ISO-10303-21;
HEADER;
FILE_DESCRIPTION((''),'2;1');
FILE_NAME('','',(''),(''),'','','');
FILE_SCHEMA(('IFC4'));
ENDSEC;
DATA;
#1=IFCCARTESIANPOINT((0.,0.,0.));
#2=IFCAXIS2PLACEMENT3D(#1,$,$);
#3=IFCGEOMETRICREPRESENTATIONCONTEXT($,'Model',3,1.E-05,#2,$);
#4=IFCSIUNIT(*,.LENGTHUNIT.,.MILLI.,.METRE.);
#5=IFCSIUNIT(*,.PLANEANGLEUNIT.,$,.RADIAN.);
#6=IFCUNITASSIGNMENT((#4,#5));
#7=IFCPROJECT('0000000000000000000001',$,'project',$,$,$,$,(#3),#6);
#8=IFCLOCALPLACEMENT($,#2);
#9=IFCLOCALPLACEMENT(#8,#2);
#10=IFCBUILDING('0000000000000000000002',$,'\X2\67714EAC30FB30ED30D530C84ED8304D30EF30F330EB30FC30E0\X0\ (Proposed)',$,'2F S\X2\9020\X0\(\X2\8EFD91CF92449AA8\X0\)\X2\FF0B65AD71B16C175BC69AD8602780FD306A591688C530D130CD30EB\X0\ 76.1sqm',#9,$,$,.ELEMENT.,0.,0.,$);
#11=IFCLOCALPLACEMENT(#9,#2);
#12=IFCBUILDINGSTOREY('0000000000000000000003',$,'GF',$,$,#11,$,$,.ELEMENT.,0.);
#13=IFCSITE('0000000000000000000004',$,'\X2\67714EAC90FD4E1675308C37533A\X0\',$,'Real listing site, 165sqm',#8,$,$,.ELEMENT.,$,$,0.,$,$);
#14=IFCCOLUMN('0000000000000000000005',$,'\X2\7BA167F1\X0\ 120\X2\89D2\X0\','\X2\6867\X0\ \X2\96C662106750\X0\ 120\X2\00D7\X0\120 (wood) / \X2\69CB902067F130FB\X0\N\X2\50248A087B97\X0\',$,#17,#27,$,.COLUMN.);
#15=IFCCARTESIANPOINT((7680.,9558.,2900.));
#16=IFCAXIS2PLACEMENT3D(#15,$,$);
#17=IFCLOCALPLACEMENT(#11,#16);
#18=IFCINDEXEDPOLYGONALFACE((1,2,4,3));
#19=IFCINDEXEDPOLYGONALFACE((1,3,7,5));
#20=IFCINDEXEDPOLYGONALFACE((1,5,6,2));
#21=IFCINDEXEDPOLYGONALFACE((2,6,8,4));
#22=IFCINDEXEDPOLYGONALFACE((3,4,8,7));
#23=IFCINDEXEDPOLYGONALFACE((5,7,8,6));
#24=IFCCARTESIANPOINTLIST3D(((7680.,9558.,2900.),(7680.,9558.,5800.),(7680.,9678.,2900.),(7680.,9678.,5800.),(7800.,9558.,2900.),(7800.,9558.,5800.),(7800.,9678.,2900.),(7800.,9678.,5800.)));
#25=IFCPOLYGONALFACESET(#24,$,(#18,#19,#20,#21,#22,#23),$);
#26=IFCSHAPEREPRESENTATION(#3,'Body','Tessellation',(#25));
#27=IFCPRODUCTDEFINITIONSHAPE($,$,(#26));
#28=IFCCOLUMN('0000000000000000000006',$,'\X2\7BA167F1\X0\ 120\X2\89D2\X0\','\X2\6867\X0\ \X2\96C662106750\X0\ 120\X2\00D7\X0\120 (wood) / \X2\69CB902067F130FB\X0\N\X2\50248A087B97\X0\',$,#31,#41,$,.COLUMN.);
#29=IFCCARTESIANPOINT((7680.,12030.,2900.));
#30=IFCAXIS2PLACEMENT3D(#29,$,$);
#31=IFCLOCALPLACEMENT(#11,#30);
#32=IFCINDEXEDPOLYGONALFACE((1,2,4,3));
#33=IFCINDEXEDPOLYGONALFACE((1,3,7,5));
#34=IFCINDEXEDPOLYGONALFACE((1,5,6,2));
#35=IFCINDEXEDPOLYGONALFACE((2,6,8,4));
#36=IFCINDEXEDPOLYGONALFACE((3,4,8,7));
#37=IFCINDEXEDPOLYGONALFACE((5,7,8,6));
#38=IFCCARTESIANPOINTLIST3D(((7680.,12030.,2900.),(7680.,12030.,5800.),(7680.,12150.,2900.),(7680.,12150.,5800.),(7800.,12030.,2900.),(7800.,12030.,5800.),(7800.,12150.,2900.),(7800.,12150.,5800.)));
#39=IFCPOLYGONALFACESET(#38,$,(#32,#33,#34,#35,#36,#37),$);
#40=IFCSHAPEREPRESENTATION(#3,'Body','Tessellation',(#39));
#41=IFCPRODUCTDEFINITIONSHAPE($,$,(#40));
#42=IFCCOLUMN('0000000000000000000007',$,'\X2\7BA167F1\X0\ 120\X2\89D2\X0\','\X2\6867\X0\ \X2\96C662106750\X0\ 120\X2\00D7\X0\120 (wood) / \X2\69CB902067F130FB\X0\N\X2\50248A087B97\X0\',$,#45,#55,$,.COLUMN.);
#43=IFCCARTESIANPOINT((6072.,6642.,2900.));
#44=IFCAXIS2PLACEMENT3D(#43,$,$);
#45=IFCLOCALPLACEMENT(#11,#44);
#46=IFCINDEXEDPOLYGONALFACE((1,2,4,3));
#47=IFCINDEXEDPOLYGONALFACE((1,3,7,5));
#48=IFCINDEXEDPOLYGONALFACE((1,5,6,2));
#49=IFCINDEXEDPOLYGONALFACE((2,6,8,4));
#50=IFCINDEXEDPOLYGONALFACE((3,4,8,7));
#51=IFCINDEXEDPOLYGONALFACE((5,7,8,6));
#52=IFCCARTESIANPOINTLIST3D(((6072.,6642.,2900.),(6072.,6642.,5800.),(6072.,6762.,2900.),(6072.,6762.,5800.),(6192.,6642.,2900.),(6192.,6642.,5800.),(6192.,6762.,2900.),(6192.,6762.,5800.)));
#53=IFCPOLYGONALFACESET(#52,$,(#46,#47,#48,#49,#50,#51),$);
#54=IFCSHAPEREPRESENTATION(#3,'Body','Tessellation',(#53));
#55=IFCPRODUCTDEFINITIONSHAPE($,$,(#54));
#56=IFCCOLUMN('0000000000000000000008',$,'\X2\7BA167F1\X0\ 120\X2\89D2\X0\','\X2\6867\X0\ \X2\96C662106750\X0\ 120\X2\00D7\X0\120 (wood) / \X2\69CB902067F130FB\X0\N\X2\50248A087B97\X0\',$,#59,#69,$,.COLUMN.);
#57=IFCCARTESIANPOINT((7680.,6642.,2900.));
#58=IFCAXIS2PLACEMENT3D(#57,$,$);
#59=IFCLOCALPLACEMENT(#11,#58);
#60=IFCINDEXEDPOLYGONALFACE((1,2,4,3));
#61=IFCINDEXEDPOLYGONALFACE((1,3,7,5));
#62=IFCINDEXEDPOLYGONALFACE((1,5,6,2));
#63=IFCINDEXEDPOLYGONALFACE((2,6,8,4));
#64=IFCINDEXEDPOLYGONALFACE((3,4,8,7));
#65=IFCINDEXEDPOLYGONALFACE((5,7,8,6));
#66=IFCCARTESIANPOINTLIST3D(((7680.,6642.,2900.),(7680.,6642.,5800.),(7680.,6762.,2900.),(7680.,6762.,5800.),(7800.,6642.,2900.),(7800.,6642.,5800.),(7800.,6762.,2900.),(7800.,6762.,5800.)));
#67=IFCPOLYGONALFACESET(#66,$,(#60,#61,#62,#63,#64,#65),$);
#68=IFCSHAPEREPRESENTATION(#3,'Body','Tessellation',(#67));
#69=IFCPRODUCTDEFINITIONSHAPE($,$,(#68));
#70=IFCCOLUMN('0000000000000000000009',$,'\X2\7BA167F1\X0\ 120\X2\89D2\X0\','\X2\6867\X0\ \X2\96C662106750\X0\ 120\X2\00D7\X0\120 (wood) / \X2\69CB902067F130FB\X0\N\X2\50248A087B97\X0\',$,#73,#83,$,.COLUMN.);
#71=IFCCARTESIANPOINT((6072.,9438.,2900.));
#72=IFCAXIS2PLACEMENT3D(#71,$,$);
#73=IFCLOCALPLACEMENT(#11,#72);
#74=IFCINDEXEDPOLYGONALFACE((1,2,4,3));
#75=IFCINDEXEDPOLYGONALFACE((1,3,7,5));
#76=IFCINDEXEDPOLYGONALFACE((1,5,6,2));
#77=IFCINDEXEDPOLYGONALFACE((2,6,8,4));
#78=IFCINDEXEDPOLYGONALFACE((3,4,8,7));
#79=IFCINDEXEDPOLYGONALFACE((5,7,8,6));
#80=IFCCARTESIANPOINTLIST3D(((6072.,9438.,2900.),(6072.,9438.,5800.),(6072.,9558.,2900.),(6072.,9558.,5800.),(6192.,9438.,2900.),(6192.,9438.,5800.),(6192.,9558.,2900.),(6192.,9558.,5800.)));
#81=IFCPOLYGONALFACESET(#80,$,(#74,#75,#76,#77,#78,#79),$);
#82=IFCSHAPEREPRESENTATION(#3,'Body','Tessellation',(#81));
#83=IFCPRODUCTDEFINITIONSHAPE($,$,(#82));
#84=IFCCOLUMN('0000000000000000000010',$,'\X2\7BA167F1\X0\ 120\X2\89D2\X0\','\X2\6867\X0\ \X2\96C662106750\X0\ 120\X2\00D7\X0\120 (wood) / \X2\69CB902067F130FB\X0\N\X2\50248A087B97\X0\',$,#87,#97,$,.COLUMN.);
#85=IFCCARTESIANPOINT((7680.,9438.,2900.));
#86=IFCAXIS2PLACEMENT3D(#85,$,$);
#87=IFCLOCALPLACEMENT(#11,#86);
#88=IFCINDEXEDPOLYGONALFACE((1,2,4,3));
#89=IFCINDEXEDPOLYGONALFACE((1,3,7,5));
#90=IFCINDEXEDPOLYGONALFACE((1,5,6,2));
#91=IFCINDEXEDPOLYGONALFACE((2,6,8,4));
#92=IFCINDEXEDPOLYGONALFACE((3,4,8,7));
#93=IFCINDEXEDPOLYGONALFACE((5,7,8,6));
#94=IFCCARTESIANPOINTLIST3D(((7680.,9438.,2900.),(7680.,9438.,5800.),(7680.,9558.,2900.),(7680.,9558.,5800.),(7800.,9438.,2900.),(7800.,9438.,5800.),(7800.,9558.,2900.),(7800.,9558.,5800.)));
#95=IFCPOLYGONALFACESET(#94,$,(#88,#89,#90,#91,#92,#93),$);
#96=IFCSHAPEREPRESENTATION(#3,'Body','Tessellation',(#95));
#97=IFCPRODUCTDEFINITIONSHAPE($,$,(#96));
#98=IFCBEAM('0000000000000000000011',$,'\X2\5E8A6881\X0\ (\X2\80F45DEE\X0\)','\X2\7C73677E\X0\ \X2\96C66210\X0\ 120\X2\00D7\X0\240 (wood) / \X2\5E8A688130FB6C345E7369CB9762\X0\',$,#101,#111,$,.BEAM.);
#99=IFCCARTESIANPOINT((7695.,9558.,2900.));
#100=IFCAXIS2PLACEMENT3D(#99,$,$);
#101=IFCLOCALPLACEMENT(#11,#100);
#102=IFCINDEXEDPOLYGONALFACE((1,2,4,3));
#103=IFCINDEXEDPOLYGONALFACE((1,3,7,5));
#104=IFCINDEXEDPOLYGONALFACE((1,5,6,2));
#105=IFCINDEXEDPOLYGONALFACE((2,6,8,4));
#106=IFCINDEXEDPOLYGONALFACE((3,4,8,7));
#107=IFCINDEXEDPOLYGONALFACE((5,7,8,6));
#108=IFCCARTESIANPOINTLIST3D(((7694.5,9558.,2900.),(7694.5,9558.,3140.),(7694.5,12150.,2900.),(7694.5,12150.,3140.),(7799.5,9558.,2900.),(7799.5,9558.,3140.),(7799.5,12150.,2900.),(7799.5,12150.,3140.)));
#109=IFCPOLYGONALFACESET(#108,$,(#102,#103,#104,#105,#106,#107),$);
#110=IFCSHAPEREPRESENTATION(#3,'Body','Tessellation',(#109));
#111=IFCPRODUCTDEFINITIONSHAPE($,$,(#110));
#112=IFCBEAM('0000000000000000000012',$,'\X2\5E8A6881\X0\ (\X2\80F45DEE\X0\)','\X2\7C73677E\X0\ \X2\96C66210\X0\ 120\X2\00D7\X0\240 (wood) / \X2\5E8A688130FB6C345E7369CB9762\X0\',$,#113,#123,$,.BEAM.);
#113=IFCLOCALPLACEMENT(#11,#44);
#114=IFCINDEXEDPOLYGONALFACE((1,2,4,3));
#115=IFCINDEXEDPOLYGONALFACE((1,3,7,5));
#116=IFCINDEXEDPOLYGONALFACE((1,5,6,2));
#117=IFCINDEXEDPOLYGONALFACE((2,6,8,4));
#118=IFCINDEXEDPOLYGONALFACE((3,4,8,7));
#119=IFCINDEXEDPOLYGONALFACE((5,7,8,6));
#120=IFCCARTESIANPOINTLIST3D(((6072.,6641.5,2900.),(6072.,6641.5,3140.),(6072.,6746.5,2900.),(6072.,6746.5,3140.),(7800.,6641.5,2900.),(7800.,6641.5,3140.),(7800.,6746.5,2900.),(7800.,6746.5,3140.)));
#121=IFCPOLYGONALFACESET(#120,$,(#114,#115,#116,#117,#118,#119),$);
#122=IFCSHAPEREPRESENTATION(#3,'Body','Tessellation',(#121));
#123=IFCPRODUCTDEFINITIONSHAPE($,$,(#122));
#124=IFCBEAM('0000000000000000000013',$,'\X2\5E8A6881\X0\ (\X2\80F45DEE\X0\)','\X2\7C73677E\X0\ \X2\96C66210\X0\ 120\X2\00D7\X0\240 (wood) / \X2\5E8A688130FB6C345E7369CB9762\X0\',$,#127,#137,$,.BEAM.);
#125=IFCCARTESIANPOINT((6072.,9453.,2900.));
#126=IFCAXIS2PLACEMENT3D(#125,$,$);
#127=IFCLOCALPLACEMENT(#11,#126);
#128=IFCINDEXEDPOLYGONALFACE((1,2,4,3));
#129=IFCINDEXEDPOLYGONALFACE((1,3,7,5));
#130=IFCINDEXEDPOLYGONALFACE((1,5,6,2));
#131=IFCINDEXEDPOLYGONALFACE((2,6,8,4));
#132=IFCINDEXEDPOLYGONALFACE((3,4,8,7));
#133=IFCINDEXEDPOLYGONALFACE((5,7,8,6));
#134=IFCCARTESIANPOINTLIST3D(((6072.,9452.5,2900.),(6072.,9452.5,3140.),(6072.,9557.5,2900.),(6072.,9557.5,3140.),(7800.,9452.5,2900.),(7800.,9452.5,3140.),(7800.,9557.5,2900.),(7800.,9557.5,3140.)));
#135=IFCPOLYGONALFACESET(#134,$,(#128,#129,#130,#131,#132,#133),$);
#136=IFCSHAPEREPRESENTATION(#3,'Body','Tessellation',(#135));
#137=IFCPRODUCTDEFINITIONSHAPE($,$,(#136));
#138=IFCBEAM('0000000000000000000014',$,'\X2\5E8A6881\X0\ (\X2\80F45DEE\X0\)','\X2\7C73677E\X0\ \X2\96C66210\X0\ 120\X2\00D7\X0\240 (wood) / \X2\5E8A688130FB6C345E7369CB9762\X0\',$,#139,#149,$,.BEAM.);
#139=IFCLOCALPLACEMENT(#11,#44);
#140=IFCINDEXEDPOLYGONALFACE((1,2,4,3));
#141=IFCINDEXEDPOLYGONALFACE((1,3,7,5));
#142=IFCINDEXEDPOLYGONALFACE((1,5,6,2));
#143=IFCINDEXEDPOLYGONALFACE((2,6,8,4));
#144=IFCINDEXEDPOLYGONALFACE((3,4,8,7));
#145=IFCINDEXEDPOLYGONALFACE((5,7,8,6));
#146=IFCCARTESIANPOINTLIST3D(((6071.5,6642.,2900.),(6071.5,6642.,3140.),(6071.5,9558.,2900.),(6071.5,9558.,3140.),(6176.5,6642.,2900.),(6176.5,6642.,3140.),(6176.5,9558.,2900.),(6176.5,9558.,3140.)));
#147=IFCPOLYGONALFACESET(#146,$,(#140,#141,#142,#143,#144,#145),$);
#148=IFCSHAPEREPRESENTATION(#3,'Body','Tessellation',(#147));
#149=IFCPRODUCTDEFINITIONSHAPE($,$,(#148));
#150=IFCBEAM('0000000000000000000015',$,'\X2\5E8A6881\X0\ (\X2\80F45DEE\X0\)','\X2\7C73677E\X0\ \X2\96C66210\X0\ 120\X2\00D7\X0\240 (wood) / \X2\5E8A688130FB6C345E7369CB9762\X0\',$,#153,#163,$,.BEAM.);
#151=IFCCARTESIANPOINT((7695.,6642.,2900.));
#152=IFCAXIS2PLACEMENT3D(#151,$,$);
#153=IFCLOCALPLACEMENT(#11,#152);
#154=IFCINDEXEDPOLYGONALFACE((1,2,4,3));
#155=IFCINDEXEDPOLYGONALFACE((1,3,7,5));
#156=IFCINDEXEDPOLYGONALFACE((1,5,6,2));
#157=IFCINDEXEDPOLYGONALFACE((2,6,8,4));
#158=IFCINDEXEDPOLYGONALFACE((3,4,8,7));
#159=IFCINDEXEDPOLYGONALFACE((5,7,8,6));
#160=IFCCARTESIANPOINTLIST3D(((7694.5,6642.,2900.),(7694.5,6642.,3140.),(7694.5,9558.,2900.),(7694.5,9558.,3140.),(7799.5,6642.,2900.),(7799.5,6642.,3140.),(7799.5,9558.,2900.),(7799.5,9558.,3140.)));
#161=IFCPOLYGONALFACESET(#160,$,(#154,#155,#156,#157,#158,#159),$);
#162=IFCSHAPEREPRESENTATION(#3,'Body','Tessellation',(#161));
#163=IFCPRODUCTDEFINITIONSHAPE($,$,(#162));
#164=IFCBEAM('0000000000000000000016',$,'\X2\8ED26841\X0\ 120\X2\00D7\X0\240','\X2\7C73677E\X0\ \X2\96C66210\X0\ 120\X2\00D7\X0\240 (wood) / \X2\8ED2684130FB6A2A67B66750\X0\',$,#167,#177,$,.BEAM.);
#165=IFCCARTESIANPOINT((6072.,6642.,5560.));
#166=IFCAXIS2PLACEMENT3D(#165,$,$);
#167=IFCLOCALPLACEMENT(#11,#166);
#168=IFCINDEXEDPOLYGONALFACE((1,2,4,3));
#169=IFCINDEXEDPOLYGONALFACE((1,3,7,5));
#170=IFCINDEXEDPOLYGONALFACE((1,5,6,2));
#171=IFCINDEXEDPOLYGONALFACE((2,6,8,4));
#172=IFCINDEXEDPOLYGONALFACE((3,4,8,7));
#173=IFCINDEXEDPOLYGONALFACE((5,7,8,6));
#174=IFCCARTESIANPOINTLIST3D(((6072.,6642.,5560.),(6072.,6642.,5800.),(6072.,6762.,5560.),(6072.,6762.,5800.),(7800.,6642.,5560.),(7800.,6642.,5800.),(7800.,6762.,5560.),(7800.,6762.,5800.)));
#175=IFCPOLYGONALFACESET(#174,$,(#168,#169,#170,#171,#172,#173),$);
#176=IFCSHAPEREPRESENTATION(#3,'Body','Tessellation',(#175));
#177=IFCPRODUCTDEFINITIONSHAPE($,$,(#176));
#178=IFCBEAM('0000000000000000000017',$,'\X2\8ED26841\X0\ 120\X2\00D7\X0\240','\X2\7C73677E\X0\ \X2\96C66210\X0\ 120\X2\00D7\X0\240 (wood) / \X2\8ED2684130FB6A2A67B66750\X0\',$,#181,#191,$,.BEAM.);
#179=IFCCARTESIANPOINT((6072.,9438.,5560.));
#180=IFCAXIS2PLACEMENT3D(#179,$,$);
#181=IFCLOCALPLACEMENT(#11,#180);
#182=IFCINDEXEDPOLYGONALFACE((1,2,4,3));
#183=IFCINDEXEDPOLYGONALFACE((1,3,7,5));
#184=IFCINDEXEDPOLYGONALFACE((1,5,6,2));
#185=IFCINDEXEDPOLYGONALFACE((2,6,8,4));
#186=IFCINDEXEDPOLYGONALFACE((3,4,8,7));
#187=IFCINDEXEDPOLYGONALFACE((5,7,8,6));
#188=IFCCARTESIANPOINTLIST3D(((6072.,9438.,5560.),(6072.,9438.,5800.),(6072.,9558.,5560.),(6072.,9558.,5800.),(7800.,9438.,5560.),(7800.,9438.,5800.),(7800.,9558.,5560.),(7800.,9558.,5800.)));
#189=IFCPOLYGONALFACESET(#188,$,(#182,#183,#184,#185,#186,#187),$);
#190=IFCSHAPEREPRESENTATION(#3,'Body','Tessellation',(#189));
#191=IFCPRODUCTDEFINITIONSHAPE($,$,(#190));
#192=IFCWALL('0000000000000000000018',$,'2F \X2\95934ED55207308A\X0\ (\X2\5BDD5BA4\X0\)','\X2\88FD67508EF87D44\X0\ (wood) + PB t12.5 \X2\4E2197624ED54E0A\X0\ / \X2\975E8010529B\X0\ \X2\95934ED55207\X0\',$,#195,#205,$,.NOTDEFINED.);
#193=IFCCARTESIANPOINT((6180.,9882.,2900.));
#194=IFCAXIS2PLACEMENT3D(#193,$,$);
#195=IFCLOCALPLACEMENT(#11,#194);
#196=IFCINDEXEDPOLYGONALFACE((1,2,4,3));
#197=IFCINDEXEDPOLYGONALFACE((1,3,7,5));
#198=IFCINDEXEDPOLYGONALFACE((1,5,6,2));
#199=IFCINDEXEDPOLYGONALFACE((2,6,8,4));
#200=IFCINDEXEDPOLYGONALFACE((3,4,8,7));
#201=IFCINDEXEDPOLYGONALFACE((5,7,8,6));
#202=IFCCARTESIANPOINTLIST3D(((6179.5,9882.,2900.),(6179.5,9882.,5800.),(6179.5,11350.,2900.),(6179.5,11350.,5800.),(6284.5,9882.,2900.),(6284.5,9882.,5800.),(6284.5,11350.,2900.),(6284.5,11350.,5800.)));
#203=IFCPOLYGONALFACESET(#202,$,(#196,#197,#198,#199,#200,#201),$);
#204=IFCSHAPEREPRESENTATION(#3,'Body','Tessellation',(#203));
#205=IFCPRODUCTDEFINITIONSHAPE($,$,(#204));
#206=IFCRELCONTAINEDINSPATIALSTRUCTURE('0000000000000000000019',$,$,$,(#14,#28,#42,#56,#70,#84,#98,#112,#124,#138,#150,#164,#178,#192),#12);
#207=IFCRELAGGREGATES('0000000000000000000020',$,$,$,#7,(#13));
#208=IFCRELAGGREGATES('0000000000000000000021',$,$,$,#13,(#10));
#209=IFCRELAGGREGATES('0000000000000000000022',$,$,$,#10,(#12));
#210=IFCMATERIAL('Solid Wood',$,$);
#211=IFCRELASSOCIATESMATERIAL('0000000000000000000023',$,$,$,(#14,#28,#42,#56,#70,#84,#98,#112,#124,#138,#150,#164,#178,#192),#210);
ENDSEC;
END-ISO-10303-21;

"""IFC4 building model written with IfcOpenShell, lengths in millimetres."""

from ifc_helpers import new_model, si_unit, frame, frame_2d, origin, place, context, project, spatial, rectangle, extrude, material, element, save


model = new_model("IFC4")

# Units and contexts
model_context = context("Model", 3, precision=1e-05, world=origin())
ifc_project = project(units=[si_unit("LENGTHUNIT", "METRE", prefix="MILLI"), si_unit("PLANEANGLEUNIT", "RADIAN")], contexts=[model_context])

# Site, building, storey
site_placement = place(None, origin())
site = spatial("IfcSite", under=ifc_project, at=site_placement, Name="東京都世田谷区", ObjectType="Real listing site, 165sqm", CompositionType="ELEMENT", RefElevation=0.0)
building_placement = place(site_placement, origin())
building = spatial("IfcBuilding", under=site, at=building_placement, Name="東京・ロフト付きワンルーム (Proposed)", ObjectType="2F S造(軽量鉄骨)＋断熱気密高性能な外装パネル 76.1sqm", CompositionType="ELEMENT", ElevationOfRefHeight=0.0, ElevationOfTerrain=0.0)
storey_placement = place(building_placement, origin())
storey = spatial("IfcBuildingStorey", under=building, at=storey_placement, Name="GF", CompositionType="ELEMENT", Elevation=0.0)

# Columns
ifc_material_1 = material(Name="Solid Wood")
column_1_placement = place(storey_placement, frame((7680.0, 9558.0, 2900.0)))
element("IfcColumn", 1, at=column_1_placement, inside=storey, material=ifc_material_1, Name="管柱 120角", Description="桧 集成材 120×120 (wood) / 構造柱・N値計算", PredefinedType="COLUMN", context=model_context, shape_type="SweptSolid", body=[
    extrude(rectangle(XDim=120.0, YDim=120.0, at=frame_2d((60.0, 60.0))), frame((7680.0, 9558.0, 2900.0)), (0.0, 0.0, 1.0), 2900.0),
])
column_2_placement = place(storey_placement, frame((7680.0, 12030.0, 2900.0)))
element("IfcColumn", 2, at=column_2_placement, inside=storey, material=ifc_material_1, Name="管柱 120角", Description="桧 集成材 120×120 (wood) / 構造柱・N値計算", PredefinedType="COLUMN", context=model_context, shape_type="SweptSolid", body=[
    extrude(rectangle(XDim=120.0, YDim=120.0, at=frame_2d((60.0, 60.0))), frame((7680.0, 12030.0, 2900.0)), (0.0, 0.0, 1.0), 2900.0),
])
column_3_placement = place(storey_placement, frame((6072.0, 6642.0, 2900.0)))
element("IfcColumn", 3, at=column_3_placement, inside=storey, material=ifc_material_1, Name="管柱 120角", Description="桧 集成材 120×120 (wood) / 構造柱・N値計算", PredefinedType="COLUMN", context=model_context, shape_type="SweptSolid", body=[
    extrude(rectangle(XDim=120.0, YDim=120.0, at=frame_2d((60.0, 60.0))), frame((6072.0, 6642.0, 2900.0)), (0.0, 0.0, 1.0), 2900.0),
])
column_4_placement = place(storey_placement, frame((7680.0, 6642.0, 2900.0)))
element("IfcColumn", 4, at=column_4_placement, inside=storey, material=ifc_material_1, Name="管柱 120角", Description="桧 集成材 120×120 (wood) / 構造柱・N値計算", PredefinedType="COLUMN", context=model_context, shape_type="SweptSolid", body=[
    extrude(rectangle(XDim=120.0, YDim=120.0, at=frame_2d((60.0, 60.0))), frame((7680.0, 6642.0, 2900.0)), (0.0, 0.0, 1.0), 2900.0),
])
column_5_placement = place(storey_placement, frame((6072.0, 9438.0, 2900.0)))
element("IfcColumn", 5, at=column_5_placement, inside=storey, material=ifc_material_1, Name="管柱 120角", Description="桧 集成材 120×120 (wood) / 構造柱・N値計算", PredefinedType="COLUMN", context=model_context, shape_type="SweptSolid", body=[
    extrude(rectangle(XDim=120.0, YDim=120.0, at=frame_2d((60.0, 60.0))), frame((6072.0, 9438.0, 2900.0)), (0.0, 0.0, 1.0), 2900.0),
])
column_6_placement = place(storey_placement, frame((7680.0, 9438.0, 2900.0)))
element("IfcColumn", 6, at=column_6_placement, inside=storey, material=ifc_material_1, Name="管柱 120角", Description="桧 集成材 120×120 (wood) / 構造柱・N値計算", PredefinedType="COLUMN", context=model_context, shape_type="SweptSolid", body=[
    extrude(rectangle(XDim=120.0, YDim=120.0, at=frame_2d((60.0, 60.0))), frame((7680.0, 9438.0, 2900.0)), (0.0, 0.0, 1.0), 2900.0),
])

# Beams
beam_1_placement = place(storey_placement, frame((7695.0, 9558.0, 2900.0)))
element("IfcBeam", 7, at=beam_1_placement, inside=storey, material=ifc_material_1, Name="床梁 (胴差)", Description="米松 集成 120×240 (wood) / 床梁・水平構面", PredefinedType="BEAM", context=model_context, shape_type="SweptSolid", body=[
    extrude(rectangle(XDim=105.0, YDim=2592.0, at=frame_2d((52.0, 1296.0))), frame((7695.0, 9558.0, 2900.0)), (0.0, 0.0, 1.0), 240.0),
])
beam_2_placement = place(storey_placement, frame((6072.0, 6642.0, 2900.0)))
element("IfcBeam", 8, at=beam_2_placement, inside=storey, material=ifc_material_1, Name="床梁 (胴差)", Description="米松 集成 120×240 (wood) / 床梁・水平構面", PredefinedType="BEAM", context=model_context, shape_type="SweptSolid", body=[
    extrude(rectangle(XDim=1728.0, YDim=105.0, at=frame_2d((864.0, 52.0))), frame((6072.0, 6642.0, 2900.0)), (0.0, 0.0, 1.0), 240.0),
])
beam_3_placement = place(storey_placement, frame((6072.0, 9453.0, 2900.0)))
element("IfcBeam", 9, at=beam_3_placement, inside=storey, material=ifc_material_1, Name="床梁 (胴差)", Description="米松 集成 120×240 (wood) / 床梁・水平構面", PredefinedType="BEAM", context=model_context, shape_type="SweptSolid", body=[
    extrude(rectangle(XDim=1728.0, YDim=105.0, at=frame_2d((864.0, 52.0))), frame((6072.0, 9453.0, 2900.0)), (0.0, 0.0, 1.0), 240.0),
])
beam_4_placement = place(storey_placement, frame((6072.0, 6642.0, 2900.0)))
element("IfcBeam", 10, at=beam_4_placement, inside=storey, material=ifc_material_1, Name="床梁 (胴差)", Description="米松 集成 120×240 (wood) / 床梁・水平構面", PredefinedType="BEAM", context=model_context, shape_type="SweptSolid", body=[
    extrude(rectangle(XDim=105.0, YDim=2916.0, at=frame_2d((52.0, 1458.0))), frame((6072.0, 6642.0, 2900.0)), (0.0, 0.0, 1.0), 240.0),
])
beam_5_placement = place(storey_placement, frame((7695.0, 6642.0, 2900.0)))
element("IfcBeam", 11, at=beam_5_placement, inside=storey, material=ifc_material_1, Name="床梁 (胴差)", Description="米松 集成 120×240 (wood) / 床梁・水平構面", PredefinedType="BEAM", context=model_context, shape_type="SweptSolid", body=[
    extrude(rectangle(XDim=105.0, YDim=2916.0, at=frame_2d((52.0, 1458.0))), frame((7695.0, 6642.0, 2900.0)), (0.0, 0.0, 1.0), 240.0),
])
beam_6_placement = place(storey_placement, frame((6072.0, 6642.0, 5560.0)))
element("IfcBeam", 12, at=beam_6_placement, inside=storey, material=ifc_material_1, Name="軒桁 120×240", Description="米松 集成 120×240 (wood) / 軒桁・横架材", PredefinedType="BEAM", context=model_context, shape_type="SweptSolid", body=[
    extrude(rectangle(XDim=1728.0, YDim=120.0, at=frame_2d((864.0, 60.0))), frame((6072.0, 6642.0, 5560.0)), (0.0, 0.0, 1.0), 240.0),
])
beam_7_placement = place(storey_placement, frame((6072.0, 9438.0, 5560.0)))
element("IfcBeam", 13, at=beam_7_placement, inside=storey, material=ifc_material_1, Name="軒桁 120×240", Description="米松 集成 120×240 (wood) / 軒桁・横架材", PredefinedType="BEAM", context=model_context, shape_type="SweptSolid", body=[
    extrude(rectangle(XDim=1728.0, YDim=120.0, at=frame_2d((864.0, 60.0))), frame((6072.0, 9438.0, 5560.0)), (0.0, 0.0, 1.0), 240.0),
])

# Wall
wall_placement = place(storey_placement, frame((6180.0, 9882.0, 2900.0)))
element("IfcWall", 14, at=wall_placement, inside=storey, material=ifc_material_1, Name="2F 間仕切り (寝室)", Description="製材軸組 (wood) + PB t12.5 両面仕上 / 非耐力 間仕切", PredefinedType="NOTDEFINED", context=model_context, shape_type="SweptSolid", body=[
    extrude(rectangle(XDim=105.0, YDim=1468.0, at=frame_2d((52.0, 734.0))), frame((6180.0, 9882.0, 2900.0)), (0.0, 0.0, 1.0), 2900.0),
])

save(model, "model.ifc")
